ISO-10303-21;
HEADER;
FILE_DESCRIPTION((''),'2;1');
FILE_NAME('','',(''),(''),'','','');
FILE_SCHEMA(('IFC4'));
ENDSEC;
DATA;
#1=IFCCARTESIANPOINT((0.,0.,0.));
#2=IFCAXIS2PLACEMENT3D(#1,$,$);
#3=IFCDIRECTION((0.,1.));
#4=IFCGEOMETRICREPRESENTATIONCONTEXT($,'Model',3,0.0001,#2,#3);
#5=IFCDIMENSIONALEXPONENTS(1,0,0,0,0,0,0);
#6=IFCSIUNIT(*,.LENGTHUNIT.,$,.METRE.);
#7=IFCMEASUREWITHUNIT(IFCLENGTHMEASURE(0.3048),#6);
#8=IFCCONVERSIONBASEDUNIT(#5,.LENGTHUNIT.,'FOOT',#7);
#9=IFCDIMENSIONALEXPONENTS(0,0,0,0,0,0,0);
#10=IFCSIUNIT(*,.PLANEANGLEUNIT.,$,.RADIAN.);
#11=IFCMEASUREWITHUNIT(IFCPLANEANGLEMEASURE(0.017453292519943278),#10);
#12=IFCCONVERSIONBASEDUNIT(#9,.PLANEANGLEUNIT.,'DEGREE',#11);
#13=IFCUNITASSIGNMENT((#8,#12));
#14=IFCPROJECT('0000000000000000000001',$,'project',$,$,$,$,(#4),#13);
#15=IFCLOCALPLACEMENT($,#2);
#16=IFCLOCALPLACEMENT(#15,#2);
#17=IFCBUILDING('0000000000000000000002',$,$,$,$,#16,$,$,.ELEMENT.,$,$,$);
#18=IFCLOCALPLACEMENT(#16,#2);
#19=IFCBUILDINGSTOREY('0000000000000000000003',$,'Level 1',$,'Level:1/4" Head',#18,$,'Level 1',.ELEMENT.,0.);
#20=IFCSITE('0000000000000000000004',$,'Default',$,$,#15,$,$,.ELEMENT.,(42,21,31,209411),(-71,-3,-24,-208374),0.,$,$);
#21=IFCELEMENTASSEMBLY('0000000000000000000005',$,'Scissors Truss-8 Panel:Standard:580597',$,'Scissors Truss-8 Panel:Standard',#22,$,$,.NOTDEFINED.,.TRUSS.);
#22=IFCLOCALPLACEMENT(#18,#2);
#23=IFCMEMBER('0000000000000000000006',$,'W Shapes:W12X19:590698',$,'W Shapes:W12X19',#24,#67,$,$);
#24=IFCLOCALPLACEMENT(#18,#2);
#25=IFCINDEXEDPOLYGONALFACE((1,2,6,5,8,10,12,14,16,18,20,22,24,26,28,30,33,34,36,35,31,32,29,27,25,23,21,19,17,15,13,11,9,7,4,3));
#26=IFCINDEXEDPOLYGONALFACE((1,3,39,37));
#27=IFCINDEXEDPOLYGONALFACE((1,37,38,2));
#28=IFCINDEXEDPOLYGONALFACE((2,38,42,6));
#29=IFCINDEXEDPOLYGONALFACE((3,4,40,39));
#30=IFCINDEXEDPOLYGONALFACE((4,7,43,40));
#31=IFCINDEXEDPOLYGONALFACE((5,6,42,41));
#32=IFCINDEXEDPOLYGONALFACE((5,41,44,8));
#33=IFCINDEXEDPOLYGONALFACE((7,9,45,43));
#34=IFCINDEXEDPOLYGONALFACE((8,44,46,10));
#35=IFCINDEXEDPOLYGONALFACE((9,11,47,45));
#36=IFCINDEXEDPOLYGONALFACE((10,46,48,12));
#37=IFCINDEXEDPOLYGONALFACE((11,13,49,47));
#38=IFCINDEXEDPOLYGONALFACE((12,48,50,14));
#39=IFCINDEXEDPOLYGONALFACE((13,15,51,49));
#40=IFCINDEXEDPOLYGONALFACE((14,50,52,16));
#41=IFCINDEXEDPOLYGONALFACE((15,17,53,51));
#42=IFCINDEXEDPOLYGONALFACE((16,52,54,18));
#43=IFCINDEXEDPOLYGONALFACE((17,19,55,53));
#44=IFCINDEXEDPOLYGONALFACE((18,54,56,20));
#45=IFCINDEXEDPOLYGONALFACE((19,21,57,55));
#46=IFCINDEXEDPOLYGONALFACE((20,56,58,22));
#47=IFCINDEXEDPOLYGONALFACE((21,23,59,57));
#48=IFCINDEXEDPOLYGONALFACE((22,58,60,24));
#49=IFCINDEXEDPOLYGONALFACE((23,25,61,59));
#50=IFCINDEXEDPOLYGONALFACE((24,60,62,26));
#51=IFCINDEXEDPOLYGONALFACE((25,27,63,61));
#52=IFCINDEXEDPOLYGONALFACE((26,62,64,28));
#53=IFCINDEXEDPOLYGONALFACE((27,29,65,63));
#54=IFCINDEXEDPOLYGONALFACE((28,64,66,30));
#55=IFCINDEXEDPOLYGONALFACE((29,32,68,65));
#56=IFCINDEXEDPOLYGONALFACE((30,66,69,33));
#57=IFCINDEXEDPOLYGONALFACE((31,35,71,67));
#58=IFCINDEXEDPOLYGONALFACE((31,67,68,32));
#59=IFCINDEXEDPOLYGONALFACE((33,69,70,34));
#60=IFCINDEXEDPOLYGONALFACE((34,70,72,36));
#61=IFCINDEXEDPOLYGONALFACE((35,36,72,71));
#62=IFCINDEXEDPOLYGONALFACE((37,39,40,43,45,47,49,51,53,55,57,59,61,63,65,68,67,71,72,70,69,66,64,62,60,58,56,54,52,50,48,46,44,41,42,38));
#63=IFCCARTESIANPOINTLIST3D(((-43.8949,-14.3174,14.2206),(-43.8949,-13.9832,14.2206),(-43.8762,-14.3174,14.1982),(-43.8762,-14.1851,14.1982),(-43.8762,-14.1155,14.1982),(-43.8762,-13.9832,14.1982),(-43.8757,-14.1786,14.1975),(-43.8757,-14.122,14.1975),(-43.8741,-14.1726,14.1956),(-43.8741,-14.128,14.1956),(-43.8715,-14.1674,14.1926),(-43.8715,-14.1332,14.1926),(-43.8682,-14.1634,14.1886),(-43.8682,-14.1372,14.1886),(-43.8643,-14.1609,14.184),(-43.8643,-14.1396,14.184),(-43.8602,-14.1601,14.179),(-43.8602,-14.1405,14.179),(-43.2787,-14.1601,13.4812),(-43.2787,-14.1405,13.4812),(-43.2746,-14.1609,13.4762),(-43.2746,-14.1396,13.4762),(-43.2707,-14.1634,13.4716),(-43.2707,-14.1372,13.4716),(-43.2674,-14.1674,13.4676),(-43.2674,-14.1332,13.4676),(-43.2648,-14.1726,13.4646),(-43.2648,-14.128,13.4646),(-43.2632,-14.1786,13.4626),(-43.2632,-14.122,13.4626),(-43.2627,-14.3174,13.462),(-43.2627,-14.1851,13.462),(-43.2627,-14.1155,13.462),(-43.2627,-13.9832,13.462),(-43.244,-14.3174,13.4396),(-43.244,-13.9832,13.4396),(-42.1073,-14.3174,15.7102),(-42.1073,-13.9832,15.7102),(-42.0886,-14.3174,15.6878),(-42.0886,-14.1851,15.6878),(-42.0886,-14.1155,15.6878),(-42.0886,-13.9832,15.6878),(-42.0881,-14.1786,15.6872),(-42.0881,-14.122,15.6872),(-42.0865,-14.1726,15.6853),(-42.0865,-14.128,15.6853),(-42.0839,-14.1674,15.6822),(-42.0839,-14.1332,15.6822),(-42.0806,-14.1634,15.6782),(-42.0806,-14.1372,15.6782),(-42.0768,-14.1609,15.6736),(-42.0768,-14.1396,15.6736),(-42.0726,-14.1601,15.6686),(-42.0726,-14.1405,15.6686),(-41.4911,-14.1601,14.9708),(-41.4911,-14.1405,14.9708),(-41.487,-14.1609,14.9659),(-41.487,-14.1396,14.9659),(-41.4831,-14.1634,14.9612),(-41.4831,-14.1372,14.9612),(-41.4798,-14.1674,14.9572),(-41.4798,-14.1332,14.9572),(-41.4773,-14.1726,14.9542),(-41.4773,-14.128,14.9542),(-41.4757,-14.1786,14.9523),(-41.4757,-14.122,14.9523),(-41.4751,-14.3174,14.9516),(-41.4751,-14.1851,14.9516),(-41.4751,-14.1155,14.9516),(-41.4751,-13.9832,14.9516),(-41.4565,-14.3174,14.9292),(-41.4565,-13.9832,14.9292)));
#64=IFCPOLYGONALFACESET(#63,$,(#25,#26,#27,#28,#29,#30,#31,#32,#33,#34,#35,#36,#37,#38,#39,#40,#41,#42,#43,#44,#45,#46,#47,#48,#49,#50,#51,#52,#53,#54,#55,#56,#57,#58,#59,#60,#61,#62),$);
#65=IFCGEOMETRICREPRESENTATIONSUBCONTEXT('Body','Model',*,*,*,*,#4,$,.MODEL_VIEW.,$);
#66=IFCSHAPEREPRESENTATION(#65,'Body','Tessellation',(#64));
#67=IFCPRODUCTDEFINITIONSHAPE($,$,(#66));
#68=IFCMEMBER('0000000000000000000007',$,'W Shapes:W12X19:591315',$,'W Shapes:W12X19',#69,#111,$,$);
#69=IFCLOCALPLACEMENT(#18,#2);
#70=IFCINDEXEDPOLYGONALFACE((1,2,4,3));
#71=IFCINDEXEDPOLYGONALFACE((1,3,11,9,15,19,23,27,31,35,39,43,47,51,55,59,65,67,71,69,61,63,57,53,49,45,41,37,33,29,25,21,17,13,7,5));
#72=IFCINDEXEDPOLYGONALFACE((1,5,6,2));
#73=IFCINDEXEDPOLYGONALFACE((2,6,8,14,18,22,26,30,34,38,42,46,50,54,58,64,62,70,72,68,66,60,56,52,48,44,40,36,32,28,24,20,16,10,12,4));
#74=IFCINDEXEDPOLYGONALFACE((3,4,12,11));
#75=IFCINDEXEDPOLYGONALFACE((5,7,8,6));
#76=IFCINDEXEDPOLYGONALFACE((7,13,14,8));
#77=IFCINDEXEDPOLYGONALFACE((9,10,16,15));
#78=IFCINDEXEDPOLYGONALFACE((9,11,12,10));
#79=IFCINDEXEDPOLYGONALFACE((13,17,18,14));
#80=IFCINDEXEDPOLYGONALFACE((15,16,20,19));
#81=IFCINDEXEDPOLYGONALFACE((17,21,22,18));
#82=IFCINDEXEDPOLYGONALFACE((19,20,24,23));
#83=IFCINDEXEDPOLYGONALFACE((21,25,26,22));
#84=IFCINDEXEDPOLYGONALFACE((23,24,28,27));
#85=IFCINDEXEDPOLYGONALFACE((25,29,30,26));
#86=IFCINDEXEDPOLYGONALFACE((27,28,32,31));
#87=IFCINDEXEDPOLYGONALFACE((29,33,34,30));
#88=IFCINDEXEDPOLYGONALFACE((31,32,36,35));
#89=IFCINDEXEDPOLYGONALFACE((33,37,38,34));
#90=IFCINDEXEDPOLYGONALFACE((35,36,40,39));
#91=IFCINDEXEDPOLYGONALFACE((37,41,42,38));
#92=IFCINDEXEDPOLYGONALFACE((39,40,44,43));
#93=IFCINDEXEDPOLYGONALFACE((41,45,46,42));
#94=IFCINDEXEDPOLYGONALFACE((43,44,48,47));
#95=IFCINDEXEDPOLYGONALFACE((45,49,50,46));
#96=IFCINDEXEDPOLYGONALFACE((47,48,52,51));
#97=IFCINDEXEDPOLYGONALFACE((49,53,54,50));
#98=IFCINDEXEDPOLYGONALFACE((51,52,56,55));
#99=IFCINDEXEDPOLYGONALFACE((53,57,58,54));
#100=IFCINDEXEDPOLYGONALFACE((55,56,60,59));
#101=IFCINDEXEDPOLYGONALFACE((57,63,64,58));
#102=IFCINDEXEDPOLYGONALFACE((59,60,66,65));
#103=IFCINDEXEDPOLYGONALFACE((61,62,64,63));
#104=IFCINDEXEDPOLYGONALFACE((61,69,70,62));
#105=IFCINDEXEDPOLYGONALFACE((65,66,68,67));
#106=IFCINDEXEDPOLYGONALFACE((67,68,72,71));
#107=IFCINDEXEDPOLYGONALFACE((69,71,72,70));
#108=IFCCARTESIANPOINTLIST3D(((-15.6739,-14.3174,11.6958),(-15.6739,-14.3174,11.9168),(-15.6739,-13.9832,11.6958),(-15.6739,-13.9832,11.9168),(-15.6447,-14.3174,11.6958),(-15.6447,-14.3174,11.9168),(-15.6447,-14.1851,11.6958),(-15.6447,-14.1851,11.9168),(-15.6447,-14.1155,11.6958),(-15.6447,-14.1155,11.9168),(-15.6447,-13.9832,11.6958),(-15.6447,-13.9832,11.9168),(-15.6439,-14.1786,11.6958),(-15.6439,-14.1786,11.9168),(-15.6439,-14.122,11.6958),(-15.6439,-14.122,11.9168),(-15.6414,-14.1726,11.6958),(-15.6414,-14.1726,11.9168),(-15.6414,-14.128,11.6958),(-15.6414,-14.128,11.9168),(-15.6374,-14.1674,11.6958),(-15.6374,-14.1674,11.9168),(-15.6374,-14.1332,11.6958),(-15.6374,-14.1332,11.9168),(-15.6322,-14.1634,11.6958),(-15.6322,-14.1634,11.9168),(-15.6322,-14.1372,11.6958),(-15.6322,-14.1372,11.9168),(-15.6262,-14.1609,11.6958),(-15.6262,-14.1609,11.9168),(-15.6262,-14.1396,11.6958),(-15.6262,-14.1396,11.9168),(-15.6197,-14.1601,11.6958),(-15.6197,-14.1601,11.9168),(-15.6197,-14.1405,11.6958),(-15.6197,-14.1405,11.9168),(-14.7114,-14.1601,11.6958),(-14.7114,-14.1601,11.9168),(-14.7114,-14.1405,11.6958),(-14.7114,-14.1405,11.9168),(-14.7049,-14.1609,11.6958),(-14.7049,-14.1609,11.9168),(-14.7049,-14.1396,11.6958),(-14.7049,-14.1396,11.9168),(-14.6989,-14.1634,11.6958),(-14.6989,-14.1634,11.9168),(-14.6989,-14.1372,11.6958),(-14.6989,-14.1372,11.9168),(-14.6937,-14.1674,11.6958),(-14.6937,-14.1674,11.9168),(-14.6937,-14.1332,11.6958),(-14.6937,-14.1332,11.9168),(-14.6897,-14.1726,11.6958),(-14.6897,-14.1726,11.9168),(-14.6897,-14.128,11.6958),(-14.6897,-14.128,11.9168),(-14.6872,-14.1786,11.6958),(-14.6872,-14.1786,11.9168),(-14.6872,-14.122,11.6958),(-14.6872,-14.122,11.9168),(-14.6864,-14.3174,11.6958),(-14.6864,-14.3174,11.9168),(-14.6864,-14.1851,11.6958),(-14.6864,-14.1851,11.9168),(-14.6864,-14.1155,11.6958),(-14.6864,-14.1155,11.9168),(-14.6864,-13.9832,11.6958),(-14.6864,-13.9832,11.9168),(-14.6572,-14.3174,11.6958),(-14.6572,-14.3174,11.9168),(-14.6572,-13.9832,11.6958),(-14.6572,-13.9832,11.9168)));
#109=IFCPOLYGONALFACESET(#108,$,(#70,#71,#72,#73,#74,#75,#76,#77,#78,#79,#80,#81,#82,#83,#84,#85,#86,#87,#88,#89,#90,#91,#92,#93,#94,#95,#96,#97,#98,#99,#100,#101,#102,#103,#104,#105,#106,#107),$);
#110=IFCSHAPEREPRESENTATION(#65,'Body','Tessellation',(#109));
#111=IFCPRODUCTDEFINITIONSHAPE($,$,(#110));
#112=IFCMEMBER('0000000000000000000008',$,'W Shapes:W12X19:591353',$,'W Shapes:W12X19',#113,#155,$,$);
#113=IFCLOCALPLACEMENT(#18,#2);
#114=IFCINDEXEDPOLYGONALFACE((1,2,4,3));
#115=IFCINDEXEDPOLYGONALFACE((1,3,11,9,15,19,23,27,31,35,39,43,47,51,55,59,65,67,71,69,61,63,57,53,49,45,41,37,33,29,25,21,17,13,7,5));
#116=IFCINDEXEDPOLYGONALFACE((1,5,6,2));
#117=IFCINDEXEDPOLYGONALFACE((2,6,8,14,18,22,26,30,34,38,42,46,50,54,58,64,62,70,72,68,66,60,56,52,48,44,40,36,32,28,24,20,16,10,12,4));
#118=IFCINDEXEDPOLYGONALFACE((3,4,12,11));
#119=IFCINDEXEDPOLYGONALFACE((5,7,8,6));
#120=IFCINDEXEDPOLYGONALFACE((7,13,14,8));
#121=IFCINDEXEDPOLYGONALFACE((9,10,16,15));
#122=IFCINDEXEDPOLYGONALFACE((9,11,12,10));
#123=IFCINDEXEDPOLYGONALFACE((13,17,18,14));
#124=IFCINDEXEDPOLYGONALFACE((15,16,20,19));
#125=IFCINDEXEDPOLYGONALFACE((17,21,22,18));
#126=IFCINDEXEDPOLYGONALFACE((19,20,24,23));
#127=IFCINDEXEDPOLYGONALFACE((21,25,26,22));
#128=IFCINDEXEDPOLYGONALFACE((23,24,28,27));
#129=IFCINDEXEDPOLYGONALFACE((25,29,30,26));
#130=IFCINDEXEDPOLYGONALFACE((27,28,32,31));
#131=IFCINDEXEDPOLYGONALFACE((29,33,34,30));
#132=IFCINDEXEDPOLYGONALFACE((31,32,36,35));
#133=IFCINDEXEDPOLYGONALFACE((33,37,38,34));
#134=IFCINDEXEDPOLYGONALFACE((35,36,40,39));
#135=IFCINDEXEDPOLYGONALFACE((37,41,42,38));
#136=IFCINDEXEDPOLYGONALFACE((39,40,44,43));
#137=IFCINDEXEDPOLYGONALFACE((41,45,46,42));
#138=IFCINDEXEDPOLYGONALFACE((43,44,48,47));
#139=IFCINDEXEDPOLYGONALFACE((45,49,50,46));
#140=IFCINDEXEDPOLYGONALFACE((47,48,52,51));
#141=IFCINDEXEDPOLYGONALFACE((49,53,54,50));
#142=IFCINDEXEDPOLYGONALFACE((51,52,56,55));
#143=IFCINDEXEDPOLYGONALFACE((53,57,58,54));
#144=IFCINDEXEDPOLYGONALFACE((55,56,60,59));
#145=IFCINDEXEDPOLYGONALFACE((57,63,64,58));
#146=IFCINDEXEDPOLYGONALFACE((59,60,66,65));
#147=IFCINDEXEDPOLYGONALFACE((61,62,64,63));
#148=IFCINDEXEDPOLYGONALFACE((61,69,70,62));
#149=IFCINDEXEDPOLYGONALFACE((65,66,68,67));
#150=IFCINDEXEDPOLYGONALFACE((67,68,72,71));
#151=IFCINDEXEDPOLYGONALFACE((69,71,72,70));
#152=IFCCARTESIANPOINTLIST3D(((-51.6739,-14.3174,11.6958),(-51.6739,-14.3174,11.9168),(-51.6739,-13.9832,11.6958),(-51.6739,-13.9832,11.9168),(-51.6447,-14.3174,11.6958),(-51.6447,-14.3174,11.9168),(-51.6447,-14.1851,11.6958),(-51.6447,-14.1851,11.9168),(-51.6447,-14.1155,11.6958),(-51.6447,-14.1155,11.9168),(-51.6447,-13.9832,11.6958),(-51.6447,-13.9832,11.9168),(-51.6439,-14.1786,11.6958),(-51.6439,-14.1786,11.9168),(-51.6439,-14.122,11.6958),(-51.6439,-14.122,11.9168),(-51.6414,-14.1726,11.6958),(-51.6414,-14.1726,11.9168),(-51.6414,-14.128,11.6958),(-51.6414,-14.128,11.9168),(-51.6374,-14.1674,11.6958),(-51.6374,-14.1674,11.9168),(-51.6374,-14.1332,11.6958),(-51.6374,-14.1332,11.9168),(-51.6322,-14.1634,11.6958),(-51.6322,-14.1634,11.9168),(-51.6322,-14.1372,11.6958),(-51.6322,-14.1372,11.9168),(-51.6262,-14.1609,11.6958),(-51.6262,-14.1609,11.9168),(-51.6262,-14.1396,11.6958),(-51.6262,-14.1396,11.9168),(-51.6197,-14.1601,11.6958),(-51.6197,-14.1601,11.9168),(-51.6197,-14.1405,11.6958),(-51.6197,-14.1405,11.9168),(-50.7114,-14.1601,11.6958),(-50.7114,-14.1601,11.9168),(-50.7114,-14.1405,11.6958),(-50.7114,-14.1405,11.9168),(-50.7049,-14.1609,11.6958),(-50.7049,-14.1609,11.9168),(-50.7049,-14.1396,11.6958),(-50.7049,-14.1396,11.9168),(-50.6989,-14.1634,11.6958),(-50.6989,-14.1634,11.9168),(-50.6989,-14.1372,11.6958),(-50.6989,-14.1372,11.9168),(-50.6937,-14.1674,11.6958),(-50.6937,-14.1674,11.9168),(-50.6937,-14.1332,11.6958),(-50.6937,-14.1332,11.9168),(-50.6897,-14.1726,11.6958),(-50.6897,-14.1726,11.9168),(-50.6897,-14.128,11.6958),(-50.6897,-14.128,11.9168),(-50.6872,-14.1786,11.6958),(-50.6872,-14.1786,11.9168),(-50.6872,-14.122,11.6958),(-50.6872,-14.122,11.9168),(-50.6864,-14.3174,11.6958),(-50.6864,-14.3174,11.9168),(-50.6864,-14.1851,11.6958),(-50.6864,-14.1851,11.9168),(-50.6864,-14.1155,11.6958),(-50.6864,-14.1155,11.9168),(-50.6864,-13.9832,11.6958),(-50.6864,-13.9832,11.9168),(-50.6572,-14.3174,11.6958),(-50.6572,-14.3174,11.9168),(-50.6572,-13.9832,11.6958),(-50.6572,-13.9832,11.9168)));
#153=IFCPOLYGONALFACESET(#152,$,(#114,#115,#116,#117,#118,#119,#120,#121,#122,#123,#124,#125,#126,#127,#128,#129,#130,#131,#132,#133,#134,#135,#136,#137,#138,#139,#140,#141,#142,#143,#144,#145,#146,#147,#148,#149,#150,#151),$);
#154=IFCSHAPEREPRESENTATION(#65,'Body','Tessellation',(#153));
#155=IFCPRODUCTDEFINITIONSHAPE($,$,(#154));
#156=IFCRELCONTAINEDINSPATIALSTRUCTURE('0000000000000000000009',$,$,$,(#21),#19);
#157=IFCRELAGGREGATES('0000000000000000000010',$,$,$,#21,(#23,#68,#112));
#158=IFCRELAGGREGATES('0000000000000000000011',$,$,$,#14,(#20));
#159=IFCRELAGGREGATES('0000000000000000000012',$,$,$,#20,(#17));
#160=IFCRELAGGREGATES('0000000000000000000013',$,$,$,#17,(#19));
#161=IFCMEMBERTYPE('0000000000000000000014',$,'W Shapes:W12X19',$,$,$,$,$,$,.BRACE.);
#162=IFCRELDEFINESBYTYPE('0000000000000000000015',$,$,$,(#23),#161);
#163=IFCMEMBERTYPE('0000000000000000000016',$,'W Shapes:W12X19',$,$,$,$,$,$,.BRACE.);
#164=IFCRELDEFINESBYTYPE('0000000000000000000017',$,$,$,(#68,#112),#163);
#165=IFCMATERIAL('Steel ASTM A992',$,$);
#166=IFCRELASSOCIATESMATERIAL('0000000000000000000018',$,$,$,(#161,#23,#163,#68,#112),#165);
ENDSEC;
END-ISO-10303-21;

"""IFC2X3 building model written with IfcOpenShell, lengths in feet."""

from ifc_helpers import new_model, entity, si_unit, converted_unit, direction, frame, frame_2d, origin, place, context, subcontext, project, spatial, polyline, circle_curve, parameter, trimmed, segment, composite_curve, outline, extrude, source, transform, mapped, material, type_object, type_shapes, element, aggregate, save


model = new_model("IFC2X3")

# Units and contexts
model_context = context("Model", 3, precision=0.0001, world=origin(), true_north=direction((0.0, 1.0)))
body_context = subcontext(model_context, "Body", "Model", "MODEL_VIEW")
ifc_project = project(units=[converted_unit("LENGTHUNIT", "FOOT", entity("IfcLengthMeasure", 0.3048), si_unit("LENGTHUNIT", "METRE"), dimensions=[1, 0, 0, 0, 0, 0, 0]), converted_unit("PLANEANGLEUNIT", "DEGREE", entity("IfcPlaneAngleMeasure", 0.017453292519943278), si_unit("PLANEANGLEUNIT", "RADIAN"), dimensions=[0, 0, 0, 0, 0, 0, 0])], contexts=[model_context])

# Site, building, storey
site_placement = place(None, origin())
site = spatial("IfcSite", under=ifc_project, at=site_placement, Name="Default", CompositionType="ELEMENT", RefLatitude=(42, 21, 31, 209411), RefLongitude=(-71, -3, -24, -208374), RefElevation=0.0)
building_placement = place(site_placement, origin())
building = spatial("IfcBuilding", under=site, at=building_placement, CompositionType="ELEMENT")
storey_placement = place(building_placement, origin())
storey = spatial("IfcBuildingStorey", under=building, at=storey_placement, Name="Level 1", ObjectType="Level:1/4\" Head", LongName="Level 1", CompositionType="ELEMENT", Elevation=0.0)

# Element assembly, members
assembly_placement = place(storey_placement, origin())
assembly = element("IfcElementAssembly", 1, at=assembly_placement, inside=storey, Name="Scissors Truss-8 Panel:Standard:580597", ObjectType="Scissors Truss-8 Panel:Standard", AssemblyPlace="NOTDEFINED", PredefinedType="TRUSS")
ifc_material = material(Name="Steel ASTM A992")
member_type_1 = type_object("IfcMemberType", Name="W Shapes:W12X19", PredefinedType="BRACE", material=ifc_material)
shared_shape_1 = source(origin(), body_context, "Body", "SweptSolid", [
    extrude(outline(composite_curve([segment(polyline([(-0.1671, -0.4792), (-0.1671, -0.5083)]), True, "CONTINUOUS"), segment(polyline([(-0.1671, -0.5083), (0.1671, -0.5083)]), True, "CONTINUOUS"), segment(polyline([(0.1671, -0.5083), (0.1671, -0.4792)]), True, "CONTINUOUS"), segment(polyline([(0.1671, -0.4792), (0.0348, -0.4792)]), True, "CONTINUOUS"), segment(trimmed(circle_curve(frame_2d((0.0348, -0.4542), x_axis=(1.0, 0.0)), 0.025), [parameter(180.0)], [parameter(270.0)], True, "PARAMETER"), False, "CONTINUOUS"), segment(polyline([(0.0098, -0.4542), (0.0098, 0.4542)]), True, "CONTINUOUS"), segment(trimmed(circle_curve(frame_2d((0.0348, 0.4542), x_axis=(1.0, 0.0)), 0.025), [parameter(90.0)], [parameter(180.0)], True, "PARAMETER"), False, "CONTINUOUS"), segment(polyline([(0.0348, 0.4792), (0.1671, 0.4792)]), True, "CONTINUOUS"), segment(polyline([(0.1671, 0.4792), (0.1671, 0.5083)]), True, "CONTINUOUS"), segment(polyline([(0.1671, 0.5083), (-0.1671, 0.5083)]), True, "CONTINUOUS"), segment(polyline([(-0.1671, 0.5083), (-0.1671, 0.4792)]), True, "CONTINUOUS"), segment(polyline([(-0.1671, 0.4792), (-0.0348, 0.4792)]), True, "CONTINUOUS"), segment(trimmed(circle_curve(frame_2d((-0.0348, 0.4542), x_axis=(1.0, 0.0)), 0.025), [parameter(360.0)], [parameter(90.0)], True, "PARAMETER"), False, "CONTINUOUS"), segment(polyline([(-0.0098, 0.4542), (-0.0098, -0.4542)]), True, "CONTINUOUS"), segment(trimmed(circle_curve(frame_2d((-0.0348, -0.4542), x_axis=(1.0, 0.0)), 0.025), [parameter(270.0)], [parameter(360.0)], True, "PARAMETER"), False, "CONTINUOUS"), segment(polyline([(-0.0348, -0.4792), (-0.1671, -0.4792)]), True, "CONTINUOUS")], self_intersect=False)), frame((-1.8275, 0.0, 0.0), z_axis=(-1.0, 0.0, 0.0), x_axis=(0.0, -1.0, 0.0)), (0.0, 0.0, -1.0), 2.3269),
])
type_shapes(member_type_1, [shared_shape_1])
member_1_placement = place(assembly_placement, frame((-42.1655, -14.1503, 15.0), z_axis=(0.640184, 0.0, -0.768221), x_axis=(0.768221, 0.0, 0.640184)))
member_1 = element("IfcMember", 2, at=member_1_placement, type_object=member_type_1, material=ifc_material, Name="W Shapes:W12X19:590698", ObjectType="W Shapes:W12X19", context=body_context, shape_type="MappedRepresentation", body=[
    mapped(shared_shape_1, transform((0.0, 0.0, 0.0), scale=1.0)),
])
member_type_2 = type_object("IfcMemberType", Name="W Shapes:W12X19", PredefinedType="BRACE", material=ifc_material)
shared_shape_2 = source(origin(), body_context, "Body", "SweptSolid", [
    extrude(outline(composite_curve([segment(polyline([(0.4792, -0.1671), (0.5083, -0.1671)]), True, "CONTINUOUS"), segment(polyline([(0.5083, -0.1671), (0.5083, 0.1671)]), True, "CONTINUOUS"), segment(polyline([(0.5083, 0.1671), (0.4792, 0.1671)]), True, "CONTINUOUS"), segment(polyline([(0.4792, 0.1671), (0.4792, 0.0348)]), True, "CONTINUOUS"), segment(trimmed(circle_curve(frame_2d((0.4542, 0.0348), x_axis=(0.0, 1.0)), 0.025), [parameter(180.0)], [parameter(270.0)], True, "PARAMETER"), False, "CONTINUOUS"), segment(polyline([(0.4542, 0.0098), (-0.4542, 0.0098)]), True, "CONTINUOUS"), segment(trimmed(circle_curve(frame_2d((-0.4542, 0.0348), x_axis=(0.0, 1.0)), 0.025), [parameter(90.0)], [parameter(180.0)], True, "PARAMETER"), False, "CONTINUOUS"), segment(polyline([(-0.4792, 0.0348), (-0.4792, 0.1671)]), True, "CONTINUOUS"), segment(polyline([(-0.4792, 0.1671), (-0.5083, 0.1671)]), True, "CONTINUOUS"), segment(polyline([(-0.5083, 0.1671), (-0.5083, -0.1671)]), True, "CONTINUOUS"), segment(polyline([(-0.5083, -0.1671), (-0.4792, -0.1671)]), True, "CONTINUOUS"), segment(polyline([(-0.4792, -0.1671), (-0.4792, -0.0348)]), True, "CONTINUOUS"), segment(trimmed(circle_curve(frame_2d((-0.4542, -0.0348), x_axis=(0.0, 1.0)), 0.025), [parameter(360.0)], [parameter(90.0)], True, "PARAMETER"), False, "CONTINUOUS"), segment(polyline([(-0.4542, -0.0098), (0.4542, -0.0098)]), True, "CONTINUOUS"), segment(trimmed(circle_curve(frame_2d((0.4542, -0.0348), x_axis=(0.0, 1.0)), 0.025), [parameter(270.0)], [parameter(360.0)], True, "PARAMETER"), False, "CONTINUOUS"), segment(polyline([(0.4792, -0.0348), (0.4792, -0.1671)]), True, "CONTINUOUS")], self_intersect=False)), frame((-0.1792, 0.0, 0.0), z_axis=(1.0, 0.0, 0.0), x_axis=(0.0, 0.0, -1.0)), (0.0, 0.0, 1.0), 0.221),
])
type_shapes(member_type_2, [shared_shape_2])
member_2_placement = place(assembly_placement, frame((-15.1655, -14.1503, 11.875), z_axis=(1.0, 0.0, 0.0), x_axis=(0.0, 0.0, 1.0)))
member_2 = element("IfcMember", 3, at=member_2_placement, type_object=member_type_2, material=ifc_material, Name="W Shapes:W12X19:591315", ObjectType="W Shapes:W12X19", context=body_context, shape_type="MappedRepresentation", body=[
    mapped(shared_shape_2, transform((0.0, 0.0, 0.0), scale=1.0)),
])
member_3_placement = place(assembly_placement, frame((-51.1655, -14.1503, 11.875), z_axis=(1.0, 0.0, 0.0), x_axis=(0.0, 0.0, 1.0)))
member_3 = element("IfcMember", 4, at=member_3_placement, type_object=member_type_2, material=ifc_material, Name="W Shapes:W12X19:591353", ObjectType="W Shapes:W12X19", context=body_context, shape_type="MappedRepresentation", body=[
    mapped(shared_shape_2, transform((0.0, 0.0, 0.0), scale=1.0)),
])
aggregate(assembly, [member_1, member_2, member_3])

save(model, "model.ifc")
